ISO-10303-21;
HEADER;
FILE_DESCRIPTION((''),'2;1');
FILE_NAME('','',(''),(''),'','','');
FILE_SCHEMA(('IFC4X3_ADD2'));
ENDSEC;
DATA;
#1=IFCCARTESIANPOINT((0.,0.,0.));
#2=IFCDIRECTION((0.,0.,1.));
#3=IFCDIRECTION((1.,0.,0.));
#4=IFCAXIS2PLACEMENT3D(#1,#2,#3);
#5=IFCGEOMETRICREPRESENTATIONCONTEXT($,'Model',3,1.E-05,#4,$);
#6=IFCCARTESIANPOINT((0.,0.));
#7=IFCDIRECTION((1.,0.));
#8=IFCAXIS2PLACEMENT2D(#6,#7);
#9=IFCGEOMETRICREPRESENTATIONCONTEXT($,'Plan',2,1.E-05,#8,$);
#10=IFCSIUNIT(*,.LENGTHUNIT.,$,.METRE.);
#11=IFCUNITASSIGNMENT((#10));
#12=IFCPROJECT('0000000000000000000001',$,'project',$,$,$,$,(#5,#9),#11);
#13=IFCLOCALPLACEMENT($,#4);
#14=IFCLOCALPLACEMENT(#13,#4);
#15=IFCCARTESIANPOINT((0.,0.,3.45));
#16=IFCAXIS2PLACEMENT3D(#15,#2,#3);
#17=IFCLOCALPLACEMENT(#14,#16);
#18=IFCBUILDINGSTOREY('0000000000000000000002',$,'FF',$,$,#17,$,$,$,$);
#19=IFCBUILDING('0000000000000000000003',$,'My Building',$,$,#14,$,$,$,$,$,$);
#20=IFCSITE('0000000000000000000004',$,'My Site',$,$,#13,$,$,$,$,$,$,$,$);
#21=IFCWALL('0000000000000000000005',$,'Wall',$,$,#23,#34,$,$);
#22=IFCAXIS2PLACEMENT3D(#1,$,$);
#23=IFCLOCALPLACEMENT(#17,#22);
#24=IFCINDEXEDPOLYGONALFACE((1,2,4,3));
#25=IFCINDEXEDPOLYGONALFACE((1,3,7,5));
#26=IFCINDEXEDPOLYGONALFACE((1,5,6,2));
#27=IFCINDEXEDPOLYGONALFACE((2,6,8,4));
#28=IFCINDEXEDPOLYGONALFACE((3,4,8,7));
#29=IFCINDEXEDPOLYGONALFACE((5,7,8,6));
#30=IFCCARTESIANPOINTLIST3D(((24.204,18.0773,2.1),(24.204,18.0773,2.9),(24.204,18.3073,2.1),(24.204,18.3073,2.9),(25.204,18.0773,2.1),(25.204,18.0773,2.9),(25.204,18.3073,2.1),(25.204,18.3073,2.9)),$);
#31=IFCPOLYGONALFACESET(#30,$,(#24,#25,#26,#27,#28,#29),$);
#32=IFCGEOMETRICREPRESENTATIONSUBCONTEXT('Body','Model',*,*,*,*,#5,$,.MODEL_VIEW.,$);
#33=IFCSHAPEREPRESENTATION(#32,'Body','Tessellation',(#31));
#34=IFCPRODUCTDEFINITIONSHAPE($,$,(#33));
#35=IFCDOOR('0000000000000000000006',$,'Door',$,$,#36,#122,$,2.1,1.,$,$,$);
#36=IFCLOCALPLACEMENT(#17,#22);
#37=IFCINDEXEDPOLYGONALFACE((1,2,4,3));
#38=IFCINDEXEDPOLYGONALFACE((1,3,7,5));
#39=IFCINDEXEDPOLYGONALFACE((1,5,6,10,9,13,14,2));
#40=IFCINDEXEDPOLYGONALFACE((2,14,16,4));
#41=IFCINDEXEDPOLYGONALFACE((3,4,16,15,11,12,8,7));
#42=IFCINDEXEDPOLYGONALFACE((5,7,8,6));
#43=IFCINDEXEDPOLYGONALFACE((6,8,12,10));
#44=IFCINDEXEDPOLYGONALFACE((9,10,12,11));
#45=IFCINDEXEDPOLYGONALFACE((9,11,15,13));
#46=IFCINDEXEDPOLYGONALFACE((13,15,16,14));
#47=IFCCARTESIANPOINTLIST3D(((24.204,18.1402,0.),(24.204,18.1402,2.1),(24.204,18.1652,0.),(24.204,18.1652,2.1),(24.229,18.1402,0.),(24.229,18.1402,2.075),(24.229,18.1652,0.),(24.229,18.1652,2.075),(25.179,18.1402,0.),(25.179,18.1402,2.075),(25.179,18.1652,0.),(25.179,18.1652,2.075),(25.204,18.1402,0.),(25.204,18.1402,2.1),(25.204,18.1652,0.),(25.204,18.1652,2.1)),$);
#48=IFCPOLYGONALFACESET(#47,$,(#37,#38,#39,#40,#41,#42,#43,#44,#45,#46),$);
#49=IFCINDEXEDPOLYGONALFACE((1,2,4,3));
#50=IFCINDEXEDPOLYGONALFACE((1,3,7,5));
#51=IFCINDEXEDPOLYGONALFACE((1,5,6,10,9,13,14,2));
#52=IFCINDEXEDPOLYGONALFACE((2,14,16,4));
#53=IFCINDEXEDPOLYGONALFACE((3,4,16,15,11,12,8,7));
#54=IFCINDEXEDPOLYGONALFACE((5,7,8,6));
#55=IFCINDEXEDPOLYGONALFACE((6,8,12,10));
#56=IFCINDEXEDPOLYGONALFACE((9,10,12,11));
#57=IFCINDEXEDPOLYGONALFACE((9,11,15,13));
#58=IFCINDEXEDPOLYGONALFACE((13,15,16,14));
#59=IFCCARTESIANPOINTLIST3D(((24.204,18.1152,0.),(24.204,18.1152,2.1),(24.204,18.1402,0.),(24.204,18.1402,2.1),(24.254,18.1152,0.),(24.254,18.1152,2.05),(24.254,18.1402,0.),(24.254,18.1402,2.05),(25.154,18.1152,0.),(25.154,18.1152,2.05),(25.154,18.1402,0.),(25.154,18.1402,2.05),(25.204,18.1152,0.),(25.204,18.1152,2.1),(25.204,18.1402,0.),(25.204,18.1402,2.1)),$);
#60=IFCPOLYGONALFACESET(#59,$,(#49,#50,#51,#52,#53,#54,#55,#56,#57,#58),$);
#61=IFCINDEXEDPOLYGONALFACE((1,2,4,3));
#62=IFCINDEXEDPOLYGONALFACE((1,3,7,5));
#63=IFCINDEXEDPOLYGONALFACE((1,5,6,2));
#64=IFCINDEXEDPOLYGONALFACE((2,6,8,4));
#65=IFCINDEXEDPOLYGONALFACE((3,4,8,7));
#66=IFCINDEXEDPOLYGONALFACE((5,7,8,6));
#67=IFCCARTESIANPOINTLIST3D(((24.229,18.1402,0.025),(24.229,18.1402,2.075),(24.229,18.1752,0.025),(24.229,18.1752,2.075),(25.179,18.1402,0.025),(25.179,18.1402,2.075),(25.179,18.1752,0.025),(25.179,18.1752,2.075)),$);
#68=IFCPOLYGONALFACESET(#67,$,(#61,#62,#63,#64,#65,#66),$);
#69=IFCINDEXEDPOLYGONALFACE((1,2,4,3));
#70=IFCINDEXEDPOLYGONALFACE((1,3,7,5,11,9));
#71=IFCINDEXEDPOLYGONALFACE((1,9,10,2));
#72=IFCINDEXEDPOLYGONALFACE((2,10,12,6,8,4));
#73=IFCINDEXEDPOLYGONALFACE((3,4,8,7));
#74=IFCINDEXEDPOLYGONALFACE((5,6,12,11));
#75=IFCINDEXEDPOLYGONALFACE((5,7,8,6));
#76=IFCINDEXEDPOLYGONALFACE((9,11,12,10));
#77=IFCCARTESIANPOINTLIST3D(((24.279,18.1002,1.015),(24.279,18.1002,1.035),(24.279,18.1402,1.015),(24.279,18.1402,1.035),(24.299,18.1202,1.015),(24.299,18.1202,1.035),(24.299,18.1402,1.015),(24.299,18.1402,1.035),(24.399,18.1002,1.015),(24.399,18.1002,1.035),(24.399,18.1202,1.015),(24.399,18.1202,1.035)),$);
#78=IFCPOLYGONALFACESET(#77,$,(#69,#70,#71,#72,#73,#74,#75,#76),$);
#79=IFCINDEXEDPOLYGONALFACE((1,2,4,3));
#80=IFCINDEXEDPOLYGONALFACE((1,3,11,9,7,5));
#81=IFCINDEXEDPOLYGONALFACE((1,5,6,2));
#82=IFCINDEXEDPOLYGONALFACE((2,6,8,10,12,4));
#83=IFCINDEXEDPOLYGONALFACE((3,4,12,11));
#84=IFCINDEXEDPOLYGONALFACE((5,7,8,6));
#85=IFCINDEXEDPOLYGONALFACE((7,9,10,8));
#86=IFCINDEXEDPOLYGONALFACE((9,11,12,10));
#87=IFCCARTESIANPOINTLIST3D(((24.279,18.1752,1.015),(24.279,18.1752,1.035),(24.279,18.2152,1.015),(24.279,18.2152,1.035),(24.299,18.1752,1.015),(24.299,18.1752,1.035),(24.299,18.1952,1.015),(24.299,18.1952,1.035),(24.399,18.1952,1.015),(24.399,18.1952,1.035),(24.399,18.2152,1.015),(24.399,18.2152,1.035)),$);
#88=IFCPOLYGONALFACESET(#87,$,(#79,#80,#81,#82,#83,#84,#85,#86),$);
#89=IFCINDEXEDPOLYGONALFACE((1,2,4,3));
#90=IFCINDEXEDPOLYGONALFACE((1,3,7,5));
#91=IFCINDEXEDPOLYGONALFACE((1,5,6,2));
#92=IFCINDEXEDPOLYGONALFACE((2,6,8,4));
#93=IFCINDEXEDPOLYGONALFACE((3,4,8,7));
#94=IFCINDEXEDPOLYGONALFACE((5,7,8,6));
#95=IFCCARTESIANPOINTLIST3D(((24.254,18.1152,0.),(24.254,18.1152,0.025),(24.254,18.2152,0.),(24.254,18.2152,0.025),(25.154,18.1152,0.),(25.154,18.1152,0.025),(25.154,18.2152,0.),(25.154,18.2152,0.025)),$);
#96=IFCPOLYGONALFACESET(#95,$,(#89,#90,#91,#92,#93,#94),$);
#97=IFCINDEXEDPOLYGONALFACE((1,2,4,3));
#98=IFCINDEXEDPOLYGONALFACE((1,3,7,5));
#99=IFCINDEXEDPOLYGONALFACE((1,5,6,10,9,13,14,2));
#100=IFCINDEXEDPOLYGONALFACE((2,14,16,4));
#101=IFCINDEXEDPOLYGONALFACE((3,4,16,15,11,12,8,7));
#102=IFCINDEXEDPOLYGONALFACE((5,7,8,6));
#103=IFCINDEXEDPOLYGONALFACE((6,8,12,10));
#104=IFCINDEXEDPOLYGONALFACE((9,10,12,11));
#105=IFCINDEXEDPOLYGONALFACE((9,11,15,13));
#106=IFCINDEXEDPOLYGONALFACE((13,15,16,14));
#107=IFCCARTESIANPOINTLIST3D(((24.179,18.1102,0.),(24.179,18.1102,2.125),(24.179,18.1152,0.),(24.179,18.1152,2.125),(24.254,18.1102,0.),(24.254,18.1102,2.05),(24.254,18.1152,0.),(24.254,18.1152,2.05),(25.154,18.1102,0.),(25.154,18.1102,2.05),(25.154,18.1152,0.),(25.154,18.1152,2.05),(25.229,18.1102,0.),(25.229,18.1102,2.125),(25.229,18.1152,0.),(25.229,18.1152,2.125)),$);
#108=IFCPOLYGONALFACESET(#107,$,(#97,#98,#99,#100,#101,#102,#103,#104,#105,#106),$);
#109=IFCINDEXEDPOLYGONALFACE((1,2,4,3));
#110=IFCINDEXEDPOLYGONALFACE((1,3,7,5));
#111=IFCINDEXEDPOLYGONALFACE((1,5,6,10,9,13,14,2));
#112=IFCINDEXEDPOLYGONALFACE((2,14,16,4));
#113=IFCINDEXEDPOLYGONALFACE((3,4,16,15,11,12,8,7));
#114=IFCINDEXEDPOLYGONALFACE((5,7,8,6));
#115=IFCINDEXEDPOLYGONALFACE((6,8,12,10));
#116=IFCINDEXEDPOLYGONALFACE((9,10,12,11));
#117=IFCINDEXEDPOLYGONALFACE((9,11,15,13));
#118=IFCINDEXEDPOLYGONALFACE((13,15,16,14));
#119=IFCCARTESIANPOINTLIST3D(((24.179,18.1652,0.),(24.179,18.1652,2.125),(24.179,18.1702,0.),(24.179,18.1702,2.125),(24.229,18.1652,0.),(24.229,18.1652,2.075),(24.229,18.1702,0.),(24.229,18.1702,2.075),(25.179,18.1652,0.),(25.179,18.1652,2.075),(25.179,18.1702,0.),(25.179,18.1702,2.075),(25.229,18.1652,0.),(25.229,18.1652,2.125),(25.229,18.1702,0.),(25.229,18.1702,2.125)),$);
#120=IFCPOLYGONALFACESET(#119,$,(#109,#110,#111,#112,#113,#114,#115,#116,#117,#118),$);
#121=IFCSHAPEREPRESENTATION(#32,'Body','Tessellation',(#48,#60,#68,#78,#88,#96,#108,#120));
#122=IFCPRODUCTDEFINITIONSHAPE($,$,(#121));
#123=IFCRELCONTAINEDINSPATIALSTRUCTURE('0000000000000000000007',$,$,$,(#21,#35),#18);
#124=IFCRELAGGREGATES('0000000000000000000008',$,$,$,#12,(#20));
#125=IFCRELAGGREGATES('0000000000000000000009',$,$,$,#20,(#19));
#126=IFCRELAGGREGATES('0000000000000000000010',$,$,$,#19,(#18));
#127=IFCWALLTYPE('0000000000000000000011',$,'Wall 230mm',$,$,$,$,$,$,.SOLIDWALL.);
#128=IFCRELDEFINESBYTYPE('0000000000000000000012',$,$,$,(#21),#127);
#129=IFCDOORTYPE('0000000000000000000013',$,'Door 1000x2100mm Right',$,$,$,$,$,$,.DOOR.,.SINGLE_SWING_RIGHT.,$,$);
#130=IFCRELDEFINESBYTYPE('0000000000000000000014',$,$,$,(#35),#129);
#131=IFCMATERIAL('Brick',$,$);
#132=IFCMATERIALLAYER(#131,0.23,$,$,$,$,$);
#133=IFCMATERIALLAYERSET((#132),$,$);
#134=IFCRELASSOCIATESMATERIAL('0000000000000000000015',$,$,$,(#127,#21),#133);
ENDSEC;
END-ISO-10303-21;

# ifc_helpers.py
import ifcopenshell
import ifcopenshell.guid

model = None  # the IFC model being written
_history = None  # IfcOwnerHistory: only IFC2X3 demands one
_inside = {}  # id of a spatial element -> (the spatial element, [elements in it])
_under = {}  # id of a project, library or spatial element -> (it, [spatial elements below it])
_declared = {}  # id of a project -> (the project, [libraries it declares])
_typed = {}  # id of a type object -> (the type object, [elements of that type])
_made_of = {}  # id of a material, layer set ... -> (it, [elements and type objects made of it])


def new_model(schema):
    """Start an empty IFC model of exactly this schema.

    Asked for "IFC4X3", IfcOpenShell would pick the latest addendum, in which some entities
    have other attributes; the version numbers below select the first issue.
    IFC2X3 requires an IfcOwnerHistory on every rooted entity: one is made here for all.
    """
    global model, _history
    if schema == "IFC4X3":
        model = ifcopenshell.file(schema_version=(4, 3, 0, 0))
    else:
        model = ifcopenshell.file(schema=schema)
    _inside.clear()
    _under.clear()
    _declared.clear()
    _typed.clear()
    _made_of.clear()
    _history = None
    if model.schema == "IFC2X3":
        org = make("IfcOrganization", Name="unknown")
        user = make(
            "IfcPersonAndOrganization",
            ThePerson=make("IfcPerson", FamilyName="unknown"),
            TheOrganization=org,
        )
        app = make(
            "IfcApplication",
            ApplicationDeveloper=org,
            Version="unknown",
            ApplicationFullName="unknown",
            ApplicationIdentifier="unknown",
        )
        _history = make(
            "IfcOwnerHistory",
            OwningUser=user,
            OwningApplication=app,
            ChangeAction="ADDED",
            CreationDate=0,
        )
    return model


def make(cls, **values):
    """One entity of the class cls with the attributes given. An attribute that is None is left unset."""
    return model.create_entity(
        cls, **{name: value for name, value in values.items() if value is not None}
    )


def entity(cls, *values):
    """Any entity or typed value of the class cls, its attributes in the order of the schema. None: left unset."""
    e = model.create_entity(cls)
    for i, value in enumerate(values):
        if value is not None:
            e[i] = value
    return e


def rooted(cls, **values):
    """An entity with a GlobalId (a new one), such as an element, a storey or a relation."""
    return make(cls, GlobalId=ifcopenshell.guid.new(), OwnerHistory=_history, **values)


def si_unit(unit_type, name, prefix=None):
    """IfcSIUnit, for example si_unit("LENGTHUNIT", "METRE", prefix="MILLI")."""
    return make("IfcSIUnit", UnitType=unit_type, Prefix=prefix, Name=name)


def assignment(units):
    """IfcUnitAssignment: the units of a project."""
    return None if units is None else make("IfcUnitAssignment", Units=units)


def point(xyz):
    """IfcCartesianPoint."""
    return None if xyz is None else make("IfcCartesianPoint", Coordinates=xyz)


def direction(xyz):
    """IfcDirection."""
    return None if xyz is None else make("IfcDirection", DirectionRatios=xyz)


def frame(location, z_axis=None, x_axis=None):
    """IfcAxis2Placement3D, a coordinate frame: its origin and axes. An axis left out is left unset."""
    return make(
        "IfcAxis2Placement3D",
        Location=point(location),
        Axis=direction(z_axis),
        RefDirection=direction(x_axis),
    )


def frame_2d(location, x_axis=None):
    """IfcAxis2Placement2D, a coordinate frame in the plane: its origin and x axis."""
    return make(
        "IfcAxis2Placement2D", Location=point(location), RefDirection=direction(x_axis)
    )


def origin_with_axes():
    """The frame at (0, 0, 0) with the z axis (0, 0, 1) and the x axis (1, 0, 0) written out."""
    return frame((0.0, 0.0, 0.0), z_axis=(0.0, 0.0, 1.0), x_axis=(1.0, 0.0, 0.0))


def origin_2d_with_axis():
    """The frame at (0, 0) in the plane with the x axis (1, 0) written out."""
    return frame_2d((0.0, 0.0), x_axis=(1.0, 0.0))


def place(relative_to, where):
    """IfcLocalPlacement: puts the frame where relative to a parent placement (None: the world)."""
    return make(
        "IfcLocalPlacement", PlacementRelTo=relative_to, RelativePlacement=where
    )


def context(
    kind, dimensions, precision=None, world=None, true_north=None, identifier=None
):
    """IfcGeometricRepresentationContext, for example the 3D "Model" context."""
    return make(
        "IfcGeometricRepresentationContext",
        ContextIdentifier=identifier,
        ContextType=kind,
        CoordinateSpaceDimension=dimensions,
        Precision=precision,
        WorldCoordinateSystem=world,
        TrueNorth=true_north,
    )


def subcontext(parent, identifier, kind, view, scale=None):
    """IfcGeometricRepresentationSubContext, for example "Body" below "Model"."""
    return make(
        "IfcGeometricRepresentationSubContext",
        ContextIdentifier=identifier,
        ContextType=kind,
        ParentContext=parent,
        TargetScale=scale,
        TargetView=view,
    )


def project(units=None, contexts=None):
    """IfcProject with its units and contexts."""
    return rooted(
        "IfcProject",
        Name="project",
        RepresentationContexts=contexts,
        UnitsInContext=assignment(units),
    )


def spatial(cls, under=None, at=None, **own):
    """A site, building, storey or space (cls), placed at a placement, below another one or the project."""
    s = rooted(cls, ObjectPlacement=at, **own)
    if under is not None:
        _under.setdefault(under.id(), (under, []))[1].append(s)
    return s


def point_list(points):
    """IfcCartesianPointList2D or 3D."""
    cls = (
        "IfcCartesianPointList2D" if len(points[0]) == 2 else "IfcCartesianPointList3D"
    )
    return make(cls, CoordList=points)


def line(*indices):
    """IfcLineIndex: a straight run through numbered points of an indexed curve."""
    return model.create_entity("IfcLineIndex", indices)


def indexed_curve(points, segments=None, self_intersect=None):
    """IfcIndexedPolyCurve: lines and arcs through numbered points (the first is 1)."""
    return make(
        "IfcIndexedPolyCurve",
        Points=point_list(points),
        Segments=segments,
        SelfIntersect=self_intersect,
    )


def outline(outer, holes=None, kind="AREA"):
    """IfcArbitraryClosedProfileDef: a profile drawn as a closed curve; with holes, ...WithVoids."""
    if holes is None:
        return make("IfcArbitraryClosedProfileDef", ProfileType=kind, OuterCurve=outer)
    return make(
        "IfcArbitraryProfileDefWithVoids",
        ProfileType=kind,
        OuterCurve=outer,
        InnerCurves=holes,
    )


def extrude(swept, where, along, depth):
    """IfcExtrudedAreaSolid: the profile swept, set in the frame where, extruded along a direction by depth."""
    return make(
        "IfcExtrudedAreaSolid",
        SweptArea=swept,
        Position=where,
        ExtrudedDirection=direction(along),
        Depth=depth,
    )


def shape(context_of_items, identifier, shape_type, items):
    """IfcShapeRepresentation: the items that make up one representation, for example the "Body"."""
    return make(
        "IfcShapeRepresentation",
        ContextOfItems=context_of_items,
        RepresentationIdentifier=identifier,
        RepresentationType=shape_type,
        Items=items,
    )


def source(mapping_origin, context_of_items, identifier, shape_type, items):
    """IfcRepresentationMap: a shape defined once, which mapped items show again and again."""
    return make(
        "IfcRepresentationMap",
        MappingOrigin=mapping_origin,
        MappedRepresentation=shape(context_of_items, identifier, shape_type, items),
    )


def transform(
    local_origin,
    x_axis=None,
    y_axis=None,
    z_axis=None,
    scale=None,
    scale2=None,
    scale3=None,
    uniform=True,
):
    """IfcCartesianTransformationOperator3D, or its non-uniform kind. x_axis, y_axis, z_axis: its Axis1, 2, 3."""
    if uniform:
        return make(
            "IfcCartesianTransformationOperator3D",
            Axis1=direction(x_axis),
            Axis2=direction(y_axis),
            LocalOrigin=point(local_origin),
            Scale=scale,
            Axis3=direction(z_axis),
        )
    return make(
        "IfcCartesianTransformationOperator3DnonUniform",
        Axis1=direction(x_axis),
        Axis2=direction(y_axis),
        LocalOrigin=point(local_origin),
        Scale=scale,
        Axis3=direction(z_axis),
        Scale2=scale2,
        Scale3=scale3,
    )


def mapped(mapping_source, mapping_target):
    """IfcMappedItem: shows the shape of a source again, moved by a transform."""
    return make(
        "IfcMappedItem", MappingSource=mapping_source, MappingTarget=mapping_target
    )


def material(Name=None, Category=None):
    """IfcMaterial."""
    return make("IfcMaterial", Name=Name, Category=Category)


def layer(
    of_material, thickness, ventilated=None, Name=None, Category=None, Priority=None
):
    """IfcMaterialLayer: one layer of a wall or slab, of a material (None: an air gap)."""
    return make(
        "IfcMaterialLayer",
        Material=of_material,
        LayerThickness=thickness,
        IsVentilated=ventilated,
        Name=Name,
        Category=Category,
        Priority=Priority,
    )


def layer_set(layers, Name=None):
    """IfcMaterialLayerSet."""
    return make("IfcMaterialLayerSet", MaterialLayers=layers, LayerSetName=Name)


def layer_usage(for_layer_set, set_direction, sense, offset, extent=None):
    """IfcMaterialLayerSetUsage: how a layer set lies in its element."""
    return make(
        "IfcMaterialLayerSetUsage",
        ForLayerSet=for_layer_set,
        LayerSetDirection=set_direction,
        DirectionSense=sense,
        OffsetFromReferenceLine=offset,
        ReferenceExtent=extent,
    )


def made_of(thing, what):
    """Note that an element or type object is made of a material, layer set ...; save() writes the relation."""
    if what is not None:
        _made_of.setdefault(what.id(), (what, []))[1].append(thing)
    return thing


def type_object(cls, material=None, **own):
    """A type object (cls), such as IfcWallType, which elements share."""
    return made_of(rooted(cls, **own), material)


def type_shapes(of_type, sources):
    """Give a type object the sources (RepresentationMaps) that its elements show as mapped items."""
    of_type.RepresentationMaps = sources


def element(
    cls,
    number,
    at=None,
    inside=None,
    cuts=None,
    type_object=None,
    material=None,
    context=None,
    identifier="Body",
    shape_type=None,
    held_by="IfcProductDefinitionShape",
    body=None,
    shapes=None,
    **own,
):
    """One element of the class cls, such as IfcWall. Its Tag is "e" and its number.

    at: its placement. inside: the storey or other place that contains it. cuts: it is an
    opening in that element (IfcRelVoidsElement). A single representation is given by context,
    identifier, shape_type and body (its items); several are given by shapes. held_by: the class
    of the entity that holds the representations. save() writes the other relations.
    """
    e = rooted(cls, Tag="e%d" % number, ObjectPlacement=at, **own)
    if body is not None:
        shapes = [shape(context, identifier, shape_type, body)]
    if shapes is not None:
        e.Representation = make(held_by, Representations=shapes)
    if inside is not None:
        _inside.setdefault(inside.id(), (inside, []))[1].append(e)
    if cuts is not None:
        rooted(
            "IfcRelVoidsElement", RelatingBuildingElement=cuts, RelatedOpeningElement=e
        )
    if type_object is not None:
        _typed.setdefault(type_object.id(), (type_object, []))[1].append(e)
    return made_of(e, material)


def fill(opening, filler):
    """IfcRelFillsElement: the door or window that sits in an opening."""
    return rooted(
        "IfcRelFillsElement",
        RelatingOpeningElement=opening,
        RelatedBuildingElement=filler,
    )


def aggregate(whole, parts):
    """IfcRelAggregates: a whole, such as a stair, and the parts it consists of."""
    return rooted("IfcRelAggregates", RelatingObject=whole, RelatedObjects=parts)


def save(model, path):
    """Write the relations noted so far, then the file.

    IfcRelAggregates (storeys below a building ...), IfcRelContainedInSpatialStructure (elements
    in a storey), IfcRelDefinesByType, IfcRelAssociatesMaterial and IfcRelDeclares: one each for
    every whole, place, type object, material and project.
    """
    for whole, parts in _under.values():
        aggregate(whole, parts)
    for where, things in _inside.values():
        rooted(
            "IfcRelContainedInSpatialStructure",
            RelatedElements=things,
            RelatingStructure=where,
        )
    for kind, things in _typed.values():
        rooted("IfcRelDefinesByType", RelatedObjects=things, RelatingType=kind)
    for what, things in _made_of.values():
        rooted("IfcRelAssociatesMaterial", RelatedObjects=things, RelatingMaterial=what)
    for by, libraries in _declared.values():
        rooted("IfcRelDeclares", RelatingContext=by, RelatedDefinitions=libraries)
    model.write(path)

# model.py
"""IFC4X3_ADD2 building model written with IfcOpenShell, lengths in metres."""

from ifc_helpers import new_model, entity, si_unit, frame, origin_with_axes, origin_2d_with_axis, place, context, subcontext, project, spatial, line, indexed_curve, outline, extrude, shape, source, transform, mapped, material, layer, layer_set, layer_usage, type_object, type_shapes, element, fill, save


model = new_model("IFC4X3_ADD2")

# Units and contexts
model_context = context("Model", 3, precision=1e-05, world=origin_with_axes())
plan_context = context("Plan", 2, precision=1e-05, world=origin_2d_with_axis())
body_context_1 = subcontext(model_context, "Body", "Model", "MODEL_VIEW")
body_context_2 = subcontext(plan_context, "Body", "Plan", "PLAN_VIEW")
ifc_project = project(units=[si_unit("LENGTHUNIT", "METRE")], contexts=[model_context, plan_context])

# Site, building, storey
site_placement = place(None, origin_with_axes())
site = spatial("IfcSite", under=ifc_project, at=site_placement, Name="My Site")
building_placement = place(site_placement, origin_with_axes())
building = spatial("IfcBuilding", under=site, at=building_placement, Name="My Building")
storey_placement = place(building_placement, frame((0.0, 0.0, 3.45), z_axis=(0.0, 0.0, 1.0), x_axis=(1.0, 0.0, 0.0)))
storey = spatial("IfcBuildingStorey", under=building, at=storey_placement, Name="FF")

# Shared definitions
ifc_material = material(Name="Brick")
ifc_layer_1 = layer(ifc_material, 0.23)
ifc_layer_set_1 = layer_set([ifc_layer_1])
wall_type_1 = type_object("IfcWallType", Name="Wall 230mm", PredefinedType="SOLIDWALL", material=ifc_layer_set_1)

# Shared definitions
shared_shape_1 = source(origin_with_axes(), body_context_1, "Body", "SweptSolid", [
    extrude(outline(indexed_curve([(0.0, 0.0), (1.0, 0.0), (1.0, 2.1), (0.0, 2.1)], segments=[line(1, 2, 3, 4, 1)])), frame((0.0, -0.6, 0.0), z_axis=(0.0, -1.0, 0.0), x_axis=(1.0, 0.0, 0.0)), (0.0, 0.0, -1.0), 1.2),
])
door_type_1 = type_object("IfcDoorType", Name="Door 1000x2100mm Right", OperationType="SINGLE_SWING_RIGHT", PredefinedType="DOOR")
shared_shape_2 = source(origin_with_axes(), body_context_1, "Body", "SweptSolid", [
    extrude(outline(indexed_curve([(0.0, 0.0), (0.0, 2.1), (1.0, 2.1), (1.0, 0.0), (0.975, 0.0), (0.975, 2.075), (0.025, 2.075), (0.025, 0.0)], segments=[line(1, 2, 3, 4, 5, 6, 7, 8, 1)])), frame((0.0, 0.025, 0.0), z_axis=(0.0, -1.0, 0.0), x_axis=(1.0, 0.0, 0.0)), (0.0, 0.0, -1.0), 0.025),
    extrude(outline(indexed_curve([(0.0, 0.0), (0.0, 2.1), (1.0, 2.1), (1.0, 0.0), (0.95, 0.0), (0.95, 2.05), (0.05, 2.05), (0.05, 0.0)], segments=[line(1, 2, 3, 4, 5, 6, 7, 8, 1)])), frame((0.0, 0.0, 0.0), z_axis=(0.0, -1.0, 0.0), x_axis=(1.0, 0.0, 0.0)), (0.0, 0.0, -1.0), 0.025),
    extrude(outline(indexed_curve([(0.0, 0.0), (0.95, 0.0), (0.95, 0.035), (0.0, 0.035)], segments=[line(1, 2, 3, 4, 1)])), frame((0.025, 0.025, 0.025), z_axis=(0.0, 0.0, 1.0), x_axis=(1.0, 0.0, 0.0)), (0.0, 0.0, 1.0), 2.05),
    extrude(outline(indexed_curve([(0.0, 0.0), (0.0, -0.04), (0.12, -0.04), (0.12, -0.02), (0.02, -0.02), (0.02, 0.0)], segments=[line(1, 2, 3, 4, 5, 6, 1)])), frame((0.075, 0.025, 1.015), z_axis=(0.0, 0.0, 1.0), x_axis=(1.0, 0.0, 0.0)), (0.0, 0.0, 1.0), 0.02),
    extrude(outline(indexed_curve([(0.0, 0.0), (0.0, 0.04), (0.12, 0.04), (0.12, 0.02), (0.02, 0.02), (0.02, 0.0)], segments=[line(1, 2, 3, 4, 5, 6, 1)])), frame((0.075, 0.06, 1.015), z_axis=(0.0, 0.0, 1.0), x_axis=(1.0, 0.0, 0.0)), (0.0, 0.0, 1.0), 0.02),
    extrude(outline(indexed_curve([(0.0, 0.0), (0.9, 0.0), (0.9, 0.1), (0.0, 0.1)], segments=[line(1, 2, 3, 4, 1)])), frame((0.05, 0.0, 0.0), z_axis=(0.0, 0.0, 1.0), x_axis=(1.0, 0.0, 0.0)), (0.0, 0.0, 1.0), 0.025),
    extrude(outline(indexed_curve([(0.0, 0.0), (0.0, 2.125), (1.05, 2.125), (1.05, 0.0), (0.975, 0.0), (0.975, 2.05), (0.075, 2.05), (0.075, 0.0)], segments=[line(1, 2, 3, 4, 5, 6, 7, 8, 1)])), frame((-0.025, -0.005, 0.0), z_axis=(0.0, -1.0, 0.0), x_axis=(1.0, 0.0, 0.0)), (0.0, 0.0, -1.0), 0.005),
    extrude(outline(indexed_curve([(0.0, 0.0), (0.0, 2.125), (1.05, 2.125), (1.05, 0.0), (1.0, 0.0), (1.0, 2.075), (0.05, 2.075), (0.05, 0.0)], segments=[line(1, 2, 3, 4, 5, 6, 7, 8, 1)])), frame((-0.025, 0.05, 0.0), z_axis=(0.0, -1.0, 0.0), x_axis=(1.0, 0.0, 0.0)), (0.0, 0.0, -1.0), 0.005),
])
shared_shape_3 = source(origin_with_axes(), body_context_2, "Body", "Curve2D", [
    entity("IfcIndexedPolyCurve", entity("IfcCartesianPointList2D", [[0.0, 0.0], [0.0, 0.05], [0.025, 0.05], [0.025, 0.025], [0.05, 0.025], [0.05, 0.0]]), [entity("IfcLineIndex", [1, 2, 3, 4, 5, 6, 1])]),
    entity("IfcIndexedPolyCurve", entity("IfcCartesianPointList2D", [[1.0, 0.0], [1.0, 0.05], [0.975, 0.05], [0.975, 0.025], [0.95, 0.025], [0.95, 0.0]]), [entity("IfcLineIndex", [1, 2, 3, 4, 5, 6, 1])]),
    entity("IfcTrimmedCurve", entity("IfcEllipse", entity("IfcAxis2Placement2D", entity("IfcCartesianPoint", [0.94, 0.05]), entity("IfcDirection", [1.0, 0.0])), 0.915, 0.95), [entity("IfcCartesianPoint", [0.94, 1.0])], [entity("IfcCartesianPoint", [0.025, 0.05])], True, "CARTESIAN"),
    entity("IfcIndexedPolyCurve", entity("IfcCartesianPointList2D", [[0.975, 0.05], [0.94, 0.05], [0.94, 1.0], [0.975, 1.0]]), [entity("IfcLineIndex", [1, 2, 3, 4, 1])]),
])
type_shapes(door_type_1, [shared_shape_2, shared_shape_3])

# Wall, opening, door
ifc_layer_usage_1 = layer_usage(ifc_layer_set_1, "AXIS2", "POSITIVE", 0.0)
wall_1_placement = place(storey_placement, frame((25.204, 18.3073, 0.0), z_axis=(0.0, 0.0, 1.0), x_axis=(-1.0, 0.0, 0.0)))
wall_1 = element("IfcWall", 1, at=wall_1_placement, inside=storey, type_object=wall_type_1, material=ifc_layer_usage_1, Name="Wall", context=body_context_1, shape_type="SweptSolid", body=[
    extrude(outline(indexed_curve([(0.0, 0.0), (0.0, 0.23), (1.0, 0.23), (1.0, 0.0), (0.0, 0.0)], self_intersect=False)), origin_with_axes(), (0.0, 0.0, 1.0), 2.9),
])
opening_1_placement = place(wall_1_placement, frame((1.0, 0.1921, 0.0), z_axis=(0.0, 0.0, 1.0), x_axis=(-1.0, 0.0, 0.0)))
opening_1 = element("IfcOpeningElement", 2, at=opening_1_placement, cuts=wall_1, PredefinedType="OPENING", context=body_context_1, shape_type="MappedRepresentation", body=[
    mapped(shared_shape_1, transform((0.0, 0.0, 0.0), x_axis=(1.0, 0.0, 0.0), y_axis=(0.0, 1.0, 0.0), z_axis=(0.0, 0.0, 1.0), scale=1.0)),
])
door_1_placement = place(opening_1_placement, frame((0.0, 0.0, 0.0), z_axis=(0.0, 0.0, 1.0), x_axis=(1.0, 0.0, 0.0)))
door_1 = element("IfcDoor", 3, at=door_1_placement, inside=storey, type_object=door_type_1, Name="Door", OverallHeight=2.1, OverallWidth=1.0, shapes=[
    shape(body_context_1, "Body", "MappedRepresentation", [mapped(shared_shape_2, transform((0.0, 0.0, 0.0), x_axis=(1.0, 0.0, 0.0), y_axis=(0.0, 1.0, 0.0), z_axis=(0.0, 0.0, 1.0), scale=1.0))]),
    shape(body_context_2, "Body", "MappedRepresentation", [mapped(shared_shape_3, transform((0.0, 0.0, 0.0), x_axis=(1.0, 0.0, 0.0), y_axis=(0.0, 1.0, 0.0), z_axis=(0.0, 0.0, 1.0), scale=1.0))]),
])
fill(opening_1, door_1)

save(model, "model.ifc")
